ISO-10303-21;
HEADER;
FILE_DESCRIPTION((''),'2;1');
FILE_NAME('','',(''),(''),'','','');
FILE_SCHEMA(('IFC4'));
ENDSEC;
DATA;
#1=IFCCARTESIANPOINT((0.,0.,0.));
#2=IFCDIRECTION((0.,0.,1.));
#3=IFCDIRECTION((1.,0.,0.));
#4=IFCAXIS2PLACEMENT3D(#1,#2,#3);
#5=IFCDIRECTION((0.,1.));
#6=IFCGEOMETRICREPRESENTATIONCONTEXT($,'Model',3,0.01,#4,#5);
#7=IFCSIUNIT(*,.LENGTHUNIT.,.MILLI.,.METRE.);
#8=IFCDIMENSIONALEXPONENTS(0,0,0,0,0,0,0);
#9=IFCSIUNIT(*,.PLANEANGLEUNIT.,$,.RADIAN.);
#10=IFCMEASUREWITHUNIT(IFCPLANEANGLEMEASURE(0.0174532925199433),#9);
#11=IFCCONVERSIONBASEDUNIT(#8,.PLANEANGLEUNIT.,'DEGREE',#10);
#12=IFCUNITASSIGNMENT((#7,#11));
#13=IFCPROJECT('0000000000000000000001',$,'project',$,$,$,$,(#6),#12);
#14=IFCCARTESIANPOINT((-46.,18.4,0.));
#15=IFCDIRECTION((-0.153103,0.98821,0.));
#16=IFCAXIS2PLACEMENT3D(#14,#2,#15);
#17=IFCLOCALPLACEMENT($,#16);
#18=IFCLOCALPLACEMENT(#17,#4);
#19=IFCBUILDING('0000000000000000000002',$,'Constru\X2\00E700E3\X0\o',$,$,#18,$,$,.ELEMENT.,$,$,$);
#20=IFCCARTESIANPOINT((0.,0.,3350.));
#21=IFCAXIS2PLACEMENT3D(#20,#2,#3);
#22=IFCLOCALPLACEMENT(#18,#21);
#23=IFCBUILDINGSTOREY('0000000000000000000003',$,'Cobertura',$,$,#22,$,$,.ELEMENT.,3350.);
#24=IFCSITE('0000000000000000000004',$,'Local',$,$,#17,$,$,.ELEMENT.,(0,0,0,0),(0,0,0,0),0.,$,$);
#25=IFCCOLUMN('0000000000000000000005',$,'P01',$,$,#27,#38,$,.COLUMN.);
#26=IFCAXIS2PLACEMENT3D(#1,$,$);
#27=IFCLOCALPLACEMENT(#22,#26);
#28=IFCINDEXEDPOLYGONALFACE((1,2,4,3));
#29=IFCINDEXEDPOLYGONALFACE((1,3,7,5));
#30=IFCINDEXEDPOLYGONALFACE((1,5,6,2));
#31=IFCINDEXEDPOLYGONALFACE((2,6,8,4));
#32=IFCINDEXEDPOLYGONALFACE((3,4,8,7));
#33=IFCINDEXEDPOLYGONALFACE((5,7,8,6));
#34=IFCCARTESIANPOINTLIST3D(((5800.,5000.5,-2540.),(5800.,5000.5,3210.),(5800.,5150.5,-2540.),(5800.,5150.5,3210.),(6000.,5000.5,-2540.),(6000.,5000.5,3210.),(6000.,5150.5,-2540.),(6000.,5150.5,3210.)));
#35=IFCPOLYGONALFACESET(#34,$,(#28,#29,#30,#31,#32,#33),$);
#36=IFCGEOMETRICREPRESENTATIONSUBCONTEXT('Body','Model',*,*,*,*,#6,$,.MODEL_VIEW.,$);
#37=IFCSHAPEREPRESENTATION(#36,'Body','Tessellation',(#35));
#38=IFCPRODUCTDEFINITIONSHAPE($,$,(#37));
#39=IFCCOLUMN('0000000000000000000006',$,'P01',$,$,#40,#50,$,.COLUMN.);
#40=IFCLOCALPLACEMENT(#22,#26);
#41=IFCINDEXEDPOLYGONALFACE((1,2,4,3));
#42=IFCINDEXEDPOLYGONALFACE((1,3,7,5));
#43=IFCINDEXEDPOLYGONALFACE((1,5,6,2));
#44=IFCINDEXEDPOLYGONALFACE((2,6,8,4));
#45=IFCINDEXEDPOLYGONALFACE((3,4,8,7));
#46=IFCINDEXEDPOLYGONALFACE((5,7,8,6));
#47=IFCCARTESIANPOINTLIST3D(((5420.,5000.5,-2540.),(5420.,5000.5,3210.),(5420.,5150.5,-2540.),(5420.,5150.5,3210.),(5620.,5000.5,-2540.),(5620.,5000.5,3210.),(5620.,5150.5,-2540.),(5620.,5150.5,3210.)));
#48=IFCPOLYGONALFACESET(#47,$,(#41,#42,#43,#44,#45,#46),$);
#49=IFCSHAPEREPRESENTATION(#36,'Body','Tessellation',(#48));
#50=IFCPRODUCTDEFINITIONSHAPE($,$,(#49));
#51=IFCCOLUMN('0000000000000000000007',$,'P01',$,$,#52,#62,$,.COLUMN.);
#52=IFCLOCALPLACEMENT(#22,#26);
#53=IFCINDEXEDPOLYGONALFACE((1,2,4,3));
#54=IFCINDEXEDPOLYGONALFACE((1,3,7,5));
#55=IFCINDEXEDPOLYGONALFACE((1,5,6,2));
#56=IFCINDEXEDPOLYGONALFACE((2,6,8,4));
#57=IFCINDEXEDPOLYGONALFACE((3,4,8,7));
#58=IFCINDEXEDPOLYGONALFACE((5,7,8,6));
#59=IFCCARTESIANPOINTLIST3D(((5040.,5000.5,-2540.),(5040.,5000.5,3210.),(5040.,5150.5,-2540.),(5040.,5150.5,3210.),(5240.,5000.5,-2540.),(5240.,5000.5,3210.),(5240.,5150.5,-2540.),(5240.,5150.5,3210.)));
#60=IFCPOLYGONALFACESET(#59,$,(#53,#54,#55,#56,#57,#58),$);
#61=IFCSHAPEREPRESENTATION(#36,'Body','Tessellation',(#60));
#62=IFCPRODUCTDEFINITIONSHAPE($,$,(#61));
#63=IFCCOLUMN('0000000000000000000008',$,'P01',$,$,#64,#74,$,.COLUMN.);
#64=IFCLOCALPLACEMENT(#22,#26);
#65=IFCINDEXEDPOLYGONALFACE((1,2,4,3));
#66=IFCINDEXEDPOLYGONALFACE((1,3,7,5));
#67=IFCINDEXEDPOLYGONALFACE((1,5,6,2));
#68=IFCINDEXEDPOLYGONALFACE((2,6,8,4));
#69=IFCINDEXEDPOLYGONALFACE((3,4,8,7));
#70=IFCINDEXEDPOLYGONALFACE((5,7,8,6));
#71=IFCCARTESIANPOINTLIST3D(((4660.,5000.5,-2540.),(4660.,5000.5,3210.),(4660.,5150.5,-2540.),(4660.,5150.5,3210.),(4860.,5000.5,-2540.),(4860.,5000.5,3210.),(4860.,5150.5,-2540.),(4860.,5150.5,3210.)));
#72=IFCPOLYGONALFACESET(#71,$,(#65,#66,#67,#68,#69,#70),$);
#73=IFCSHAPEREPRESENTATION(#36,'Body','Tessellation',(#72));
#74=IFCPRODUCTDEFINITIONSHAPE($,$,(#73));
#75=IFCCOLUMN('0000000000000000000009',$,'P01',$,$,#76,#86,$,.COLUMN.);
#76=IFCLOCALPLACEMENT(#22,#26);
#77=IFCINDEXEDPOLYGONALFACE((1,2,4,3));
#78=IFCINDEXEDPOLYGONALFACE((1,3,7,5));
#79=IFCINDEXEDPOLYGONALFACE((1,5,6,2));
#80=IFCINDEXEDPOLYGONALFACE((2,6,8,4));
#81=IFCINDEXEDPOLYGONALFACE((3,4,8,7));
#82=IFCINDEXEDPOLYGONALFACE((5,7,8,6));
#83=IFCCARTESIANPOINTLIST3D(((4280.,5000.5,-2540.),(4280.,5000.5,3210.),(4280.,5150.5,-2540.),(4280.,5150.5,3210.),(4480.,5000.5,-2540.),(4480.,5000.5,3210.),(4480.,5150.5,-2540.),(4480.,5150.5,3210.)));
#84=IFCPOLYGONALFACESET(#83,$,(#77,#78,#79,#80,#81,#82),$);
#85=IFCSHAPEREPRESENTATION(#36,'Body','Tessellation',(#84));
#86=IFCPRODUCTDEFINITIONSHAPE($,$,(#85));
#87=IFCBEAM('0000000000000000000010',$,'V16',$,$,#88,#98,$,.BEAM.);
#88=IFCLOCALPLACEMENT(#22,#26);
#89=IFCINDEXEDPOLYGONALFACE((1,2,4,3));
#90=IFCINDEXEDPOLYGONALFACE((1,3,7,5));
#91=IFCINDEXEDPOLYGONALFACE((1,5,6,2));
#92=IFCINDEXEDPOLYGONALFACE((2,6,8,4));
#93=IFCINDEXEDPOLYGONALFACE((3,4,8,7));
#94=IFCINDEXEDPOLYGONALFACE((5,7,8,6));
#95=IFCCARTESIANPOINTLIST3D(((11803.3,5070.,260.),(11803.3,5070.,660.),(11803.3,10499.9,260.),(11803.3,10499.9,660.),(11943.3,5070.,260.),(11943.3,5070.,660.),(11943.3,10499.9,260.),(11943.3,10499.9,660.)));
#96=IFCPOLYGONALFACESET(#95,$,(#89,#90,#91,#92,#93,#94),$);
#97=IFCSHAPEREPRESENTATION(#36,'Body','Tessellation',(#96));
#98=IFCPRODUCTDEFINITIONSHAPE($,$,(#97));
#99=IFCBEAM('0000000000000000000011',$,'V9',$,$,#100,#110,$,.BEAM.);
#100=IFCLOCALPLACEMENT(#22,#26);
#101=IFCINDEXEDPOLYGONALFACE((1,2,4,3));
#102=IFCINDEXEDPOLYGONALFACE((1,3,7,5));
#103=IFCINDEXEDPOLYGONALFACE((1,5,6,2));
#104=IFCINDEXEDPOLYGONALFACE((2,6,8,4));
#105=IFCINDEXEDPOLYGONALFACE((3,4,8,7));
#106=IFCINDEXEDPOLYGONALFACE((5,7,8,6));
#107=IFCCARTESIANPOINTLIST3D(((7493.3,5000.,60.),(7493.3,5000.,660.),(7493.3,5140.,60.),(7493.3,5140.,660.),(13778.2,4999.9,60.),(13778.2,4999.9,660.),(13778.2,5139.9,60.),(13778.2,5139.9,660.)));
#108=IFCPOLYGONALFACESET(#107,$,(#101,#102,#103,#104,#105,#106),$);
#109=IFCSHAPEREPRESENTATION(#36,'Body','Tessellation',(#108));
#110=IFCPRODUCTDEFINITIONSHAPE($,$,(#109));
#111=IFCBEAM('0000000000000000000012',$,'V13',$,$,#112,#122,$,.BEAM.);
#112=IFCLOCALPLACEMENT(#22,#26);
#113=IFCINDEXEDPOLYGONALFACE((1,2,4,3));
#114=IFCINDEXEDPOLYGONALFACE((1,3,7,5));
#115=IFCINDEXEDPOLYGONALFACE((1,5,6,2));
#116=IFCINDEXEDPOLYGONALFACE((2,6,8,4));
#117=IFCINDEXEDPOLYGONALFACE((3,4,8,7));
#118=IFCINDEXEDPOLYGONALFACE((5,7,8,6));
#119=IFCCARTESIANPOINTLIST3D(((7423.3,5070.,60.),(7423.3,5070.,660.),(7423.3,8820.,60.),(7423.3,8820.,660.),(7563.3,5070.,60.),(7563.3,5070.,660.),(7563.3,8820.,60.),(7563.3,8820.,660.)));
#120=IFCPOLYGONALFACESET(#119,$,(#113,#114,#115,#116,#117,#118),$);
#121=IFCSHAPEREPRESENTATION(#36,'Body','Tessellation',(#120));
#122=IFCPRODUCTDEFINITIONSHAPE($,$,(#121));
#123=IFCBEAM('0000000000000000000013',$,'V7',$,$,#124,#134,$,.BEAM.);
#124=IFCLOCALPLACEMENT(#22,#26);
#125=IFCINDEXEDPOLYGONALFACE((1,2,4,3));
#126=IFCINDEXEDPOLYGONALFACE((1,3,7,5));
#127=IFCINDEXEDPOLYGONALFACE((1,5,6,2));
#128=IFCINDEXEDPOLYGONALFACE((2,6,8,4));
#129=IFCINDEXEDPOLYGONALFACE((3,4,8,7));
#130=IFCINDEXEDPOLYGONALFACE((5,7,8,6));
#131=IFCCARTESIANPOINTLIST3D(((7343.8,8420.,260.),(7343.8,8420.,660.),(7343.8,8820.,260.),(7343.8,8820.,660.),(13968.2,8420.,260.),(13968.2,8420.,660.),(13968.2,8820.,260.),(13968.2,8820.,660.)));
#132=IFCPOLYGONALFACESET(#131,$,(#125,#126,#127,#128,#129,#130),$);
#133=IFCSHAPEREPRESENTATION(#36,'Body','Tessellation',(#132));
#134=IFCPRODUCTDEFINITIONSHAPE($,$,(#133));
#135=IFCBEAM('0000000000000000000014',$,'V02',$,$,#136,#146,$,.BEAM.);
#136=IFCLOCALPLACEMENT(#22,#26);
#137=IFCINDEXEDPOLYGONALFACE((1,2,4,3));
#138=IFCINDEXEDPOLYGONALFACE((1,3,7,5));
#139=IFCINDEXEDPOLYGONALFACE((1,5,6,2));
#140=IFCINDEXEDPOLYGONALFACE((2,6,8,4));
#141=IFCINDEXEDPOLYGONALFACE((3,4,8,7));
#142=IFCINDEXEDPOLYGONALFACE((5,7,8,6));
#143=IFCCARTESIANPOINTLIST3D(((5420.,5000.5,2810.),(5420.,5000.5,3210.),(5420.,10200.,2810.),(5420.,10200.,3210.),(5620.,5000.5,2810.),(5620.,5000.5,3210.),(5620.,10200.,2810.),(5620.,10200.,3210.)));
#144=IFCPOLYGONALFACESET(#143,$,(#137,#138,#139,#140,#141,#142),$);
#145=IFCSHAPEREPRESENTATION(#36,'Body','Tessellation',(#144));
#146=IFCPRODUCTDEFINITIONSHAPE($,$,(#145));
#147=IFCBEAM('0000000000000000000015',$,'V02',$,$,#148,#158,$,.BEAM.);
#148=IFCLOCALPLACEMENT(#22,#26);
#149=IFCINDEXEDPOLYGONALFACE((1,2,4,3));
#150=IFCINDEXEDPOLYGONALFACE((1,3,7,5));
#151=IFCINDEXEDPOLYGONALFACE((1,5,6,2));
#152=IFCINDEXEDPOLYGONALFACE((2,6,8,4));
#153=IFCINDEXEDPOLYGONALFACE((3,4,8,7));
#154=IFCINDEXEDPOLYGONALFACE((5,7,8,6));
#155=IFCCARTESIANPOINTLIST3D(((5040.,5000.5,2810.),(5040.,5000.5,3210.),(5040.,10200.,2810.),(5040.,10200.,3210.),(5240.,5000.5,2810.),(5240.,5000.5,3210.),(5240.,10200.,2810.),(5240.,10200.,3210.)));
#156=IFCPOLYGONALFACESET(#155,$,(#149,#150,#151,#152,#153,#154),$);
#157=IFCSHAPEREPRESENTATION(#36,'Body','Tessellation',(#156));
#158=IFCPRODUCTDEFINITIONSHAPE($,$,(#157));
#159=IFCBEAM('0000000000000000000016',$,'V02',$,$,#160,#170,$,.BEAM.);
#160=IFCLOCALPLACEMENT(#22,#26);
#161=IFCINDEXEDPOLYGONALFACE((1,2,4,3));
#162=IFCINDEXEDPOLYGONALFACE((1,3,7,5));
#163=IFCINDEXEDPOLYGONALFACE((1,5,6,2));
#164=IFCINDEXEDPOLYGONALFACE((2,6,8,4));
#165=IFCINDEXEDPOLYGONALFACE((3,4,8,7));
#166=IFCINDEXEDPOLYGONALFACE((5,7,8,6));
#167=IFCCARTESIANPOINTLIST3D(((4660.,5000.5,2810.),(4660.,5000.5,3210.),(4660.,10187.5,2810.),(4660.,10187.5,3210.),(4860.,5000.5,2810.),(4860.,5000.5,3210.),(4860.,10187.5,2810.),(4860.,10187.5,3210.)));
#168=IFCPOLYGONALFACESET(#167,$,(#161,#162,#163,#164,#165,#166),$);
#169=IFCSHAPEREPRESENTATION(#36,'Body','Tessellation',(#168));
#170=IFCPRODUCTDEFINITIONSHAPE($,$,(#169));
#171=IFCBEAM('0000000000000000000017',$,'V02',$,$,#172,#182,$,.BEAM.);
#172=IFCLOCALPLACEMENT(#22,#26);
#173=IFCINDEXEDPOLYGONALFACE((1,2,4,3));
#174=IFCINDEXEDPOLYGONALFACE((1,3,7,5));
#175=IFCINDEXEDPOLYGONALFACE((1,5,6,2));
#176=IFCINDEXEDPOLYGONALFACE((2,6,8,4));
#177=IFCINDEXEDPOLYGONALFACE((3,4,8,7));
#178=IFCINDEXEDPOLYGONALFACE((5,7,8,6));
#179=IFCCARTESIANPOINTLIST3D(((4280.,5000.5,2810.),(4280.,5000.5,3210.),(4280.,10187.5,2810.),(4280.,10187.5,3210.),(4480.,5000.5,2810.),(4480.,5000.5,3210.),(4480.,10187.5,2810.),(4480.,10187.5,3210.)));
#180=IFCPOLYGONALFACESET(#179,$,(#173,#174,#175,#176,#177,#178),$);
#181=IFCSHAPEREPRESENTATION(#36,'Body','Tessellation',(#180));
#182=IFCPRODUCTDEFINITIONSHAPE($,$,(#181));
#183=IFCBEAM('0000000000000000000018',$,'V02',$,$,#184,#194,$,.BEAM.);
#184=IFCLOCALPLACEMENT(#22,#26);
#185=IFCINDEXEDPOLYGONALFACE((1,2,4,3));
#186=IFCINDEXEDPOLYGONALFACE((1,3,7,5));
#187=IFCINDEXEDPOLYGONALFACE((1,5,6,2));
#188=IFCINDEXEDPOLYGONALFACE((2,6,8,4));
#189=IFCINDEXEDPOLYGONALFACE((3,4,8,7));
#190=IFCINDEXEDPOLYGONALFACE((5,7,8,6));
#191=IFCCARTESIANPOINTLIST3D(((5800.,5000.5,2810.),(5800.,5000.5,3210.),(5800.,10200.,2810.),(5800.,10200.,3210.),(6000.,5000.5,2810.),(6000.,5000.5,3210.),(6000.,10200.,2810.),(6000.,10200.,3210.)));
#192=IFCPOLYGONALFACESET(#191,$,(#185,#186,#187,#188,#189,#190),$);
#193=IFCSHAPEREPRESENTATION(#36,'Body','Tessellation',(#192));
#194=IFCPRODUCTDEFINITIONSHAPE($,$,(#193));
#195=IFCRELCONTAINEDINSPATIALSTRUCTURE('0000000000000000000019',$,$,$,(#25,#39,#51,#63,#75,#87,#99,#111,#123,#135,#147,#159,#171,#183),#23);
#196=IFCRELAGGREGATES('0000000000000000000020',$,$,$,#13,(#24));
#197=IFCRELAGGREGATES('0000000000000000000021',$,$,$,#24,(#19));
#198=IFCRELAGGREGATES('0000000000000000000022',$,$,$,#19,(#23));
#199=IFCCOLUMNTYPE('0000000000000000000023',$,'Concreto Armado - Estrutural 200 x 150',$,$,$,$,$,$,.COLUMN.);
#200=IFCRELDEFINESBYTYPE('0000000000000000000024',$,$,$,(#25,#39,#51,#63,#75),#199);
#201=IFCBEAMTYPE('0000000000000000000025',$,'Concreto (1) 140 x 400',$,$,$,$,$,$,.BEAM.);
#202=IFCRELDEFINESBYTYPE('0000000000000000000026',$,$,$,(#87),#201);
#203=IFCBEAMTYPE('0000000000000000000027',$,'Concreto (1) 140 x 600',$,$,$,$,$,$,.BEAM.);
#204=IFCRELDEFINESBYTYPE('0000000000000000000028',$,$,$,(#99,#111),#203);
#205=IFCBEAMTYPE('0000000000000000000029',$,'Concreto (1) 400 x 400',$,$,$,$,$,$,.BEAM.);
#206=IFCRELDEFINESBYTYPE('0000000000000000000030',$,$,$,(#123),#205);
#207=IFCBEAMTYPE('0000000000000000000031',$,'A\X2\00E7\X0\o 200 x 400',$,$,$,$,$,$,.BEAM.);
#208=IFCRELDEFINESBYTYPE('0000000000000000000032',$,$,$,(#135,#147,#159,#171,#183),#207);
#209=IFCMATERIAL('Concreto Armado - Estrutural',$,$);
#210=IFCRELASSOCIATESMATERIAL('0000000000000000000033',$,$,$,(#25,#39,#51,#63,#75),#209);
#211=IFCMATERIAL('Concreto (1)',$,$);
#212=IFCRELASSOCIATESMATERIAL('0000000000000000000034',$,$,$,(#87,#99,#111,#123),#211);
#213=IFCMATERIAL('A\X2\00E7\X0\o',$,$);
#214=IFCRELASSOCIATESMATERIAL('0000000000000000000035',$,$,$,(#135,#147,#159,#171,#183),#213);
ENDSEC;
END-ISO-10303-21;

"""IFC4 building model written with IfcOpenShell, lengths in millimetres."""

from ifc_helpers import new_model, entity, si_unit, converted_unit, direction, frame, frame_2d, origin_with_axes, origin_2d_with_axis, place, context, subcontext, project, spatial, rectangle, extrude, material, type_object, element, save


model = new_model("IFC4")

# Units and contexts
model_context = context("Model", 3, precision=0.01, world=origin_with_axes(), true_north=direction((0.0, 1.0)))
body_context = subcontext(model_context, "Body", "Model", "MODEL_VIEW")
ifc_project = project(units=[si_unit("LENGTHUNIT", "METRE", prefix="MILLI"), converted_unit("PLANEANGLEUNIT", "DEGREE", entity("IfcPlaneAngleMeasure", 0.0174532925199433), si_unit("PLANEANGLEUNIT", "RADIAN"), dimensions=[0, 0, 0, 0, 0, 0, 0])], contexts=[model_context])

# Site, building, storey
site_placement = place(None, frame((-46.0, 18.4, 0.0), z_axis=(0.0, 0.0, 1.0), x_axis=(-0.153103, 0.98821, 0.0)))
site = spatial("IfcSite", under=ifc_project, at=site_placement, Name="Local", CompositionType="ELEMENT", RefLatitude=(0, 0, 0, 0), RefLongitude=(0, 0, 0, 0), RefElevation=0.0)
building_placement = place(site_placement, origin_with_axes())
building = spatial("IfcBuilding", under=site, at=building_placement, Name="Construção", CompositionType="ELEMENT")
storey_placement = place(building_placement, frame((0.0, 0.0, 3350.0), z_axis=(0.0, 0.0, 1.0), x_axis=(1.0, 0.0, 0.0)))
storey = spatial("IfcBuildingStorey", under=building, at=storey_placement, Name="Cobertura", CompositionType="ELEMENT", Elevation=3350.0)

# Columns
ifc_material_1 = material(Name="Concreto Armado - Estrutural")
column_type = type_object("IfcColumnType", Name="Concreto Armado - Estrutural 200 x 150", PredefinedType="COLUMN")
for number, where, z_axis, x_axis, name in (
    (1, (5900.0, 5075.5, -2540.0), (0.0, 0.0, 1.0), (1.0, 0.0, 0.0), "P01"),
    (2, (5520.0, 5075.5, -2540.0), (0.0, 0.0, 1.0), (1.0, 0.0, 0.0), "P01"),
    (3, (5140.0, 5075.5, -2540.0), (0.0, 0.0, 1.0), (1.0, 0.0, 0.0), "P01"),
    (4, (4760.0, 5075.5, -2540.0), (0.0, 0.0, 1.0), (1.0, 0.0, 0.0), "P01"),
    (5, (4380.0, 5075.5, -2540.0), (0.0, 0.0, 1.0), (1.0, 0.0, 0.0), "P01"),
):
    element("IfcColumn", number, at=place(storey_placement, frame(where, z_axis=z_axis, x_axis=x_axis)), inside=storey, type_object=column_type, material=ifc_material_1, Name=name, PredefinedType="COLUMN", context=body_context, shape_type="SweptSolid", body=[
        extrude(rectangle(XDim=200.0, YDim=150.0, at=origin_2d_with_axis()), origin_with_axes(), (0.0, 0.0, 1.0), 5750.0),
    ])

# Beams
ifc_material_2 = material(Name="Concreto (1)")
beam_type_1 = type_object("IfcBeamType", Name="Concreto (1) 140 x 400", PredefinedType="BEAM")
beam_1_placement = place(storey_placement, frame((11873.3, 10499.9, 660.0), z_axis=(0.0, 0.0, 1.0), x_axis=(-1.0, 0.0, 0.0)))
element("IfcBeam", 6, at=beam_1_placement, inside=storey, type_object=beam_type_1, material=ifc_material_2, Name="V16", PredefinedType="BEAM", context=body_context, shape_type="SweptSolid", body=[
    extrude(rectangle(XDim=400.0, YDim=140.0, at=frame_2d((-200.0, 0.0), x_axis=(1.0, 0.0))), frame((0.0, 0.0, 0.0), z_axis=(0.0, 1.0, 0.0), x_axis=(0.0, 0.0, 1.0)), (0.0, 0.0, 1.0), 5429.9),
])
beam_type_2 = type_object("IfcBeamType", Name="Concreto (1) 140 x 600", PredefinedType="BEAM")
beam_2_placement = place(storey_placement, frame((13778.2, 5069.9, 660.0), z_axis=(0.0, 0.0, 1.0), x_axis=(0.000016, 1.0, 0.0)))
element("IfcBeam", 7, at=beam_2_placement, inside=storey, type_object=beam_type_2, material=ifc_material_2, Name="V9", PredefinedType="BEAM", context=body_context, shape_type="SweptSolid", body=[
    extrude(rectangle(XDim=600.0, YDim=140.0, at=frame_2d((-300.0, 0.0), x_axis=(1.0, 0.0))), frame((0.0, 0.0, 0.0), z_axis=(0.0, 1.0, 0.0), x_axis=(0.0, 0.0, 1.0)), (0.0, 0.0, 1.0), 6284.9),
])
beam_3_placement = place(storey_placement, frame((7493.3, 8820.0, 660.0), z_axis=(0.0, 0.0, 1.0), x_axis=(-1.0, 0.0, 0.0)))
element("IfcBeam", 8, at=beam_3_placement, inside=storey, type_object=beam_type_2, material=ifc_material_2, Name="V13", PredefinedType="BEAM", context=body_context, shape_type="SweptSolid", body=[
    extrude(rectangle(XDim=600.0, YDim=140.0, at=frame_2d((-300.0, 0.0), x_axis=(1.0, 0.0))), frame((0.0, 0.0, 0.0), z_axis=(0.0, 1.0, 0.0), x_axis=(0.0, 0.0, 1.0)), (0.0, 0.0, 1.0), 3750.0),
])
beam_type_3 = type_object("IfcBeamType", Name="Concreto (1) 400 x 400", PredefinedType="BEAM")
beam_4_placement = place(storey_placement, frame((13968.2, 8620.0, 660.0), z_axis=(0.0, 0.0, 1.0), x_axis=(0.0, 1.0, 0.0)))
element("IfcBeam", 9, at=beam_4_placement, inside=storey, type_object=beam_type_3, material=ifc_material_2, Name="V7", PredefinedType="BEAM", context=body_context, shape_type="SweptSolid", body=[
    extrude(rectangle(XDim=400.0, YDim=400.0, at=frame_2d((-200.0, 0.0), x_axis=(1.0, 0.0))), frame((0.0, 0.0, 0.0), z_axis=(0.0, 1.0, 0.0), x_axis=(0.0, 0.0, 1.0)), (0.0, 0.0, 1.0), 6624.4),
])
ifc_material_3 = material(Name="Aço")
beam_type_4 = type_object("IfcBeamType", Name="Aço 200 x 400", PredefinedType="BEAM")
for number, where, z_axis, x_axis, name in (
    (10, (5520.0, 10200.0, 3210.0), (0.0, 0.0, 1.0), (-1.0, 0.0, 0.0), "V02"),
    (11, (5140.0, 10200.0, 3210.0), (0.0, 0.0, 1.0), (-1.0, 0.0, 0.0), "V02"),
):
    element("IfcBeam", number, at=place(storey_placement, frame(where, z_axis=z_axis, x_axis=x_axis)), inside=storey, type_object=beam_type_4, material=ifc_material_3, Name=name, PredefinedType="BEAM", context=body_context, shape_type="SweptSolid", body=[
        extrude(rectangle(XDim=400.0, YDim=200.0, at=frame_2d((-200.0, 0.0), x_axis=(1.0, 0.0))), frame((0.0, 0.0, 0.0), z_axis=(0.0, 1.0, 0.0), x_axis=(0.0, 0.0, 1.0)), (0.0, 0.0, 1.0), 5199.5),
    ])
for number, where, z_axis, x_axis, name in (
    (12, (4760.0, 10187.5, 3210.0), (0.0, 0.0, 1.0), (-1.0, 0.0, 0.0), "V02"),
    (13, (4380.0, 10187.5, 3210.0), (0.0, 0.0, 1.0), (-1.0, 0.0, 0.0), "V02"),
):
    element("IfcBeam", number, at=place(storey_placement, frame(where, z_axis=z_axis, x_axis=x_axis)), inside=storey, type_object=beam_type_4, material=ifc_material_3, Name=name, PredefinedType="BEAM", context=body_context, shape_type="SweptSolid", body=[
        extrude(rectangle(XDim=400.0, YDim=200.0, at=frame_2d((-200.0, 0.0), x_axis=(1.0, 0.0))), frame((0.0, 0.0, 0.0), z_axis=(0.0, 1.0, 0.0), x_axis=(0.0, 0.0, 1.0)), (0.0, 0.0, 1.0), 5187.0),
    ])
beam_5_placement = place(storey_placement, frame((5900.0, 10200.0, 3210.0), z_axis=(0.0, 0.0, 1.0), x_axis=(-1.0, 0.0, 0.0)))
element("IfcBeam", 14, at=beam_5_placement, inside=storey, type_object=beam_type_4, material=ifc_material_3, Name="V02", PredefinedType="BEAM", context=body_context, shape_type="SweptSolid", body=[
    extrude(rectangle(XDim=400.0, YDim=200.0, at=frame_2d((-200.0, 0.0), x_axis=(1.0, 0.0))), frame((0.0, 0.0, 0.0), z_axis=(0.0, 1.0, 0.0), x_axis=(0.0, 0.0, 1.0)), (0.0, 0.0, 1.0), 5199.5),
])

save(model, "model.ifc")
